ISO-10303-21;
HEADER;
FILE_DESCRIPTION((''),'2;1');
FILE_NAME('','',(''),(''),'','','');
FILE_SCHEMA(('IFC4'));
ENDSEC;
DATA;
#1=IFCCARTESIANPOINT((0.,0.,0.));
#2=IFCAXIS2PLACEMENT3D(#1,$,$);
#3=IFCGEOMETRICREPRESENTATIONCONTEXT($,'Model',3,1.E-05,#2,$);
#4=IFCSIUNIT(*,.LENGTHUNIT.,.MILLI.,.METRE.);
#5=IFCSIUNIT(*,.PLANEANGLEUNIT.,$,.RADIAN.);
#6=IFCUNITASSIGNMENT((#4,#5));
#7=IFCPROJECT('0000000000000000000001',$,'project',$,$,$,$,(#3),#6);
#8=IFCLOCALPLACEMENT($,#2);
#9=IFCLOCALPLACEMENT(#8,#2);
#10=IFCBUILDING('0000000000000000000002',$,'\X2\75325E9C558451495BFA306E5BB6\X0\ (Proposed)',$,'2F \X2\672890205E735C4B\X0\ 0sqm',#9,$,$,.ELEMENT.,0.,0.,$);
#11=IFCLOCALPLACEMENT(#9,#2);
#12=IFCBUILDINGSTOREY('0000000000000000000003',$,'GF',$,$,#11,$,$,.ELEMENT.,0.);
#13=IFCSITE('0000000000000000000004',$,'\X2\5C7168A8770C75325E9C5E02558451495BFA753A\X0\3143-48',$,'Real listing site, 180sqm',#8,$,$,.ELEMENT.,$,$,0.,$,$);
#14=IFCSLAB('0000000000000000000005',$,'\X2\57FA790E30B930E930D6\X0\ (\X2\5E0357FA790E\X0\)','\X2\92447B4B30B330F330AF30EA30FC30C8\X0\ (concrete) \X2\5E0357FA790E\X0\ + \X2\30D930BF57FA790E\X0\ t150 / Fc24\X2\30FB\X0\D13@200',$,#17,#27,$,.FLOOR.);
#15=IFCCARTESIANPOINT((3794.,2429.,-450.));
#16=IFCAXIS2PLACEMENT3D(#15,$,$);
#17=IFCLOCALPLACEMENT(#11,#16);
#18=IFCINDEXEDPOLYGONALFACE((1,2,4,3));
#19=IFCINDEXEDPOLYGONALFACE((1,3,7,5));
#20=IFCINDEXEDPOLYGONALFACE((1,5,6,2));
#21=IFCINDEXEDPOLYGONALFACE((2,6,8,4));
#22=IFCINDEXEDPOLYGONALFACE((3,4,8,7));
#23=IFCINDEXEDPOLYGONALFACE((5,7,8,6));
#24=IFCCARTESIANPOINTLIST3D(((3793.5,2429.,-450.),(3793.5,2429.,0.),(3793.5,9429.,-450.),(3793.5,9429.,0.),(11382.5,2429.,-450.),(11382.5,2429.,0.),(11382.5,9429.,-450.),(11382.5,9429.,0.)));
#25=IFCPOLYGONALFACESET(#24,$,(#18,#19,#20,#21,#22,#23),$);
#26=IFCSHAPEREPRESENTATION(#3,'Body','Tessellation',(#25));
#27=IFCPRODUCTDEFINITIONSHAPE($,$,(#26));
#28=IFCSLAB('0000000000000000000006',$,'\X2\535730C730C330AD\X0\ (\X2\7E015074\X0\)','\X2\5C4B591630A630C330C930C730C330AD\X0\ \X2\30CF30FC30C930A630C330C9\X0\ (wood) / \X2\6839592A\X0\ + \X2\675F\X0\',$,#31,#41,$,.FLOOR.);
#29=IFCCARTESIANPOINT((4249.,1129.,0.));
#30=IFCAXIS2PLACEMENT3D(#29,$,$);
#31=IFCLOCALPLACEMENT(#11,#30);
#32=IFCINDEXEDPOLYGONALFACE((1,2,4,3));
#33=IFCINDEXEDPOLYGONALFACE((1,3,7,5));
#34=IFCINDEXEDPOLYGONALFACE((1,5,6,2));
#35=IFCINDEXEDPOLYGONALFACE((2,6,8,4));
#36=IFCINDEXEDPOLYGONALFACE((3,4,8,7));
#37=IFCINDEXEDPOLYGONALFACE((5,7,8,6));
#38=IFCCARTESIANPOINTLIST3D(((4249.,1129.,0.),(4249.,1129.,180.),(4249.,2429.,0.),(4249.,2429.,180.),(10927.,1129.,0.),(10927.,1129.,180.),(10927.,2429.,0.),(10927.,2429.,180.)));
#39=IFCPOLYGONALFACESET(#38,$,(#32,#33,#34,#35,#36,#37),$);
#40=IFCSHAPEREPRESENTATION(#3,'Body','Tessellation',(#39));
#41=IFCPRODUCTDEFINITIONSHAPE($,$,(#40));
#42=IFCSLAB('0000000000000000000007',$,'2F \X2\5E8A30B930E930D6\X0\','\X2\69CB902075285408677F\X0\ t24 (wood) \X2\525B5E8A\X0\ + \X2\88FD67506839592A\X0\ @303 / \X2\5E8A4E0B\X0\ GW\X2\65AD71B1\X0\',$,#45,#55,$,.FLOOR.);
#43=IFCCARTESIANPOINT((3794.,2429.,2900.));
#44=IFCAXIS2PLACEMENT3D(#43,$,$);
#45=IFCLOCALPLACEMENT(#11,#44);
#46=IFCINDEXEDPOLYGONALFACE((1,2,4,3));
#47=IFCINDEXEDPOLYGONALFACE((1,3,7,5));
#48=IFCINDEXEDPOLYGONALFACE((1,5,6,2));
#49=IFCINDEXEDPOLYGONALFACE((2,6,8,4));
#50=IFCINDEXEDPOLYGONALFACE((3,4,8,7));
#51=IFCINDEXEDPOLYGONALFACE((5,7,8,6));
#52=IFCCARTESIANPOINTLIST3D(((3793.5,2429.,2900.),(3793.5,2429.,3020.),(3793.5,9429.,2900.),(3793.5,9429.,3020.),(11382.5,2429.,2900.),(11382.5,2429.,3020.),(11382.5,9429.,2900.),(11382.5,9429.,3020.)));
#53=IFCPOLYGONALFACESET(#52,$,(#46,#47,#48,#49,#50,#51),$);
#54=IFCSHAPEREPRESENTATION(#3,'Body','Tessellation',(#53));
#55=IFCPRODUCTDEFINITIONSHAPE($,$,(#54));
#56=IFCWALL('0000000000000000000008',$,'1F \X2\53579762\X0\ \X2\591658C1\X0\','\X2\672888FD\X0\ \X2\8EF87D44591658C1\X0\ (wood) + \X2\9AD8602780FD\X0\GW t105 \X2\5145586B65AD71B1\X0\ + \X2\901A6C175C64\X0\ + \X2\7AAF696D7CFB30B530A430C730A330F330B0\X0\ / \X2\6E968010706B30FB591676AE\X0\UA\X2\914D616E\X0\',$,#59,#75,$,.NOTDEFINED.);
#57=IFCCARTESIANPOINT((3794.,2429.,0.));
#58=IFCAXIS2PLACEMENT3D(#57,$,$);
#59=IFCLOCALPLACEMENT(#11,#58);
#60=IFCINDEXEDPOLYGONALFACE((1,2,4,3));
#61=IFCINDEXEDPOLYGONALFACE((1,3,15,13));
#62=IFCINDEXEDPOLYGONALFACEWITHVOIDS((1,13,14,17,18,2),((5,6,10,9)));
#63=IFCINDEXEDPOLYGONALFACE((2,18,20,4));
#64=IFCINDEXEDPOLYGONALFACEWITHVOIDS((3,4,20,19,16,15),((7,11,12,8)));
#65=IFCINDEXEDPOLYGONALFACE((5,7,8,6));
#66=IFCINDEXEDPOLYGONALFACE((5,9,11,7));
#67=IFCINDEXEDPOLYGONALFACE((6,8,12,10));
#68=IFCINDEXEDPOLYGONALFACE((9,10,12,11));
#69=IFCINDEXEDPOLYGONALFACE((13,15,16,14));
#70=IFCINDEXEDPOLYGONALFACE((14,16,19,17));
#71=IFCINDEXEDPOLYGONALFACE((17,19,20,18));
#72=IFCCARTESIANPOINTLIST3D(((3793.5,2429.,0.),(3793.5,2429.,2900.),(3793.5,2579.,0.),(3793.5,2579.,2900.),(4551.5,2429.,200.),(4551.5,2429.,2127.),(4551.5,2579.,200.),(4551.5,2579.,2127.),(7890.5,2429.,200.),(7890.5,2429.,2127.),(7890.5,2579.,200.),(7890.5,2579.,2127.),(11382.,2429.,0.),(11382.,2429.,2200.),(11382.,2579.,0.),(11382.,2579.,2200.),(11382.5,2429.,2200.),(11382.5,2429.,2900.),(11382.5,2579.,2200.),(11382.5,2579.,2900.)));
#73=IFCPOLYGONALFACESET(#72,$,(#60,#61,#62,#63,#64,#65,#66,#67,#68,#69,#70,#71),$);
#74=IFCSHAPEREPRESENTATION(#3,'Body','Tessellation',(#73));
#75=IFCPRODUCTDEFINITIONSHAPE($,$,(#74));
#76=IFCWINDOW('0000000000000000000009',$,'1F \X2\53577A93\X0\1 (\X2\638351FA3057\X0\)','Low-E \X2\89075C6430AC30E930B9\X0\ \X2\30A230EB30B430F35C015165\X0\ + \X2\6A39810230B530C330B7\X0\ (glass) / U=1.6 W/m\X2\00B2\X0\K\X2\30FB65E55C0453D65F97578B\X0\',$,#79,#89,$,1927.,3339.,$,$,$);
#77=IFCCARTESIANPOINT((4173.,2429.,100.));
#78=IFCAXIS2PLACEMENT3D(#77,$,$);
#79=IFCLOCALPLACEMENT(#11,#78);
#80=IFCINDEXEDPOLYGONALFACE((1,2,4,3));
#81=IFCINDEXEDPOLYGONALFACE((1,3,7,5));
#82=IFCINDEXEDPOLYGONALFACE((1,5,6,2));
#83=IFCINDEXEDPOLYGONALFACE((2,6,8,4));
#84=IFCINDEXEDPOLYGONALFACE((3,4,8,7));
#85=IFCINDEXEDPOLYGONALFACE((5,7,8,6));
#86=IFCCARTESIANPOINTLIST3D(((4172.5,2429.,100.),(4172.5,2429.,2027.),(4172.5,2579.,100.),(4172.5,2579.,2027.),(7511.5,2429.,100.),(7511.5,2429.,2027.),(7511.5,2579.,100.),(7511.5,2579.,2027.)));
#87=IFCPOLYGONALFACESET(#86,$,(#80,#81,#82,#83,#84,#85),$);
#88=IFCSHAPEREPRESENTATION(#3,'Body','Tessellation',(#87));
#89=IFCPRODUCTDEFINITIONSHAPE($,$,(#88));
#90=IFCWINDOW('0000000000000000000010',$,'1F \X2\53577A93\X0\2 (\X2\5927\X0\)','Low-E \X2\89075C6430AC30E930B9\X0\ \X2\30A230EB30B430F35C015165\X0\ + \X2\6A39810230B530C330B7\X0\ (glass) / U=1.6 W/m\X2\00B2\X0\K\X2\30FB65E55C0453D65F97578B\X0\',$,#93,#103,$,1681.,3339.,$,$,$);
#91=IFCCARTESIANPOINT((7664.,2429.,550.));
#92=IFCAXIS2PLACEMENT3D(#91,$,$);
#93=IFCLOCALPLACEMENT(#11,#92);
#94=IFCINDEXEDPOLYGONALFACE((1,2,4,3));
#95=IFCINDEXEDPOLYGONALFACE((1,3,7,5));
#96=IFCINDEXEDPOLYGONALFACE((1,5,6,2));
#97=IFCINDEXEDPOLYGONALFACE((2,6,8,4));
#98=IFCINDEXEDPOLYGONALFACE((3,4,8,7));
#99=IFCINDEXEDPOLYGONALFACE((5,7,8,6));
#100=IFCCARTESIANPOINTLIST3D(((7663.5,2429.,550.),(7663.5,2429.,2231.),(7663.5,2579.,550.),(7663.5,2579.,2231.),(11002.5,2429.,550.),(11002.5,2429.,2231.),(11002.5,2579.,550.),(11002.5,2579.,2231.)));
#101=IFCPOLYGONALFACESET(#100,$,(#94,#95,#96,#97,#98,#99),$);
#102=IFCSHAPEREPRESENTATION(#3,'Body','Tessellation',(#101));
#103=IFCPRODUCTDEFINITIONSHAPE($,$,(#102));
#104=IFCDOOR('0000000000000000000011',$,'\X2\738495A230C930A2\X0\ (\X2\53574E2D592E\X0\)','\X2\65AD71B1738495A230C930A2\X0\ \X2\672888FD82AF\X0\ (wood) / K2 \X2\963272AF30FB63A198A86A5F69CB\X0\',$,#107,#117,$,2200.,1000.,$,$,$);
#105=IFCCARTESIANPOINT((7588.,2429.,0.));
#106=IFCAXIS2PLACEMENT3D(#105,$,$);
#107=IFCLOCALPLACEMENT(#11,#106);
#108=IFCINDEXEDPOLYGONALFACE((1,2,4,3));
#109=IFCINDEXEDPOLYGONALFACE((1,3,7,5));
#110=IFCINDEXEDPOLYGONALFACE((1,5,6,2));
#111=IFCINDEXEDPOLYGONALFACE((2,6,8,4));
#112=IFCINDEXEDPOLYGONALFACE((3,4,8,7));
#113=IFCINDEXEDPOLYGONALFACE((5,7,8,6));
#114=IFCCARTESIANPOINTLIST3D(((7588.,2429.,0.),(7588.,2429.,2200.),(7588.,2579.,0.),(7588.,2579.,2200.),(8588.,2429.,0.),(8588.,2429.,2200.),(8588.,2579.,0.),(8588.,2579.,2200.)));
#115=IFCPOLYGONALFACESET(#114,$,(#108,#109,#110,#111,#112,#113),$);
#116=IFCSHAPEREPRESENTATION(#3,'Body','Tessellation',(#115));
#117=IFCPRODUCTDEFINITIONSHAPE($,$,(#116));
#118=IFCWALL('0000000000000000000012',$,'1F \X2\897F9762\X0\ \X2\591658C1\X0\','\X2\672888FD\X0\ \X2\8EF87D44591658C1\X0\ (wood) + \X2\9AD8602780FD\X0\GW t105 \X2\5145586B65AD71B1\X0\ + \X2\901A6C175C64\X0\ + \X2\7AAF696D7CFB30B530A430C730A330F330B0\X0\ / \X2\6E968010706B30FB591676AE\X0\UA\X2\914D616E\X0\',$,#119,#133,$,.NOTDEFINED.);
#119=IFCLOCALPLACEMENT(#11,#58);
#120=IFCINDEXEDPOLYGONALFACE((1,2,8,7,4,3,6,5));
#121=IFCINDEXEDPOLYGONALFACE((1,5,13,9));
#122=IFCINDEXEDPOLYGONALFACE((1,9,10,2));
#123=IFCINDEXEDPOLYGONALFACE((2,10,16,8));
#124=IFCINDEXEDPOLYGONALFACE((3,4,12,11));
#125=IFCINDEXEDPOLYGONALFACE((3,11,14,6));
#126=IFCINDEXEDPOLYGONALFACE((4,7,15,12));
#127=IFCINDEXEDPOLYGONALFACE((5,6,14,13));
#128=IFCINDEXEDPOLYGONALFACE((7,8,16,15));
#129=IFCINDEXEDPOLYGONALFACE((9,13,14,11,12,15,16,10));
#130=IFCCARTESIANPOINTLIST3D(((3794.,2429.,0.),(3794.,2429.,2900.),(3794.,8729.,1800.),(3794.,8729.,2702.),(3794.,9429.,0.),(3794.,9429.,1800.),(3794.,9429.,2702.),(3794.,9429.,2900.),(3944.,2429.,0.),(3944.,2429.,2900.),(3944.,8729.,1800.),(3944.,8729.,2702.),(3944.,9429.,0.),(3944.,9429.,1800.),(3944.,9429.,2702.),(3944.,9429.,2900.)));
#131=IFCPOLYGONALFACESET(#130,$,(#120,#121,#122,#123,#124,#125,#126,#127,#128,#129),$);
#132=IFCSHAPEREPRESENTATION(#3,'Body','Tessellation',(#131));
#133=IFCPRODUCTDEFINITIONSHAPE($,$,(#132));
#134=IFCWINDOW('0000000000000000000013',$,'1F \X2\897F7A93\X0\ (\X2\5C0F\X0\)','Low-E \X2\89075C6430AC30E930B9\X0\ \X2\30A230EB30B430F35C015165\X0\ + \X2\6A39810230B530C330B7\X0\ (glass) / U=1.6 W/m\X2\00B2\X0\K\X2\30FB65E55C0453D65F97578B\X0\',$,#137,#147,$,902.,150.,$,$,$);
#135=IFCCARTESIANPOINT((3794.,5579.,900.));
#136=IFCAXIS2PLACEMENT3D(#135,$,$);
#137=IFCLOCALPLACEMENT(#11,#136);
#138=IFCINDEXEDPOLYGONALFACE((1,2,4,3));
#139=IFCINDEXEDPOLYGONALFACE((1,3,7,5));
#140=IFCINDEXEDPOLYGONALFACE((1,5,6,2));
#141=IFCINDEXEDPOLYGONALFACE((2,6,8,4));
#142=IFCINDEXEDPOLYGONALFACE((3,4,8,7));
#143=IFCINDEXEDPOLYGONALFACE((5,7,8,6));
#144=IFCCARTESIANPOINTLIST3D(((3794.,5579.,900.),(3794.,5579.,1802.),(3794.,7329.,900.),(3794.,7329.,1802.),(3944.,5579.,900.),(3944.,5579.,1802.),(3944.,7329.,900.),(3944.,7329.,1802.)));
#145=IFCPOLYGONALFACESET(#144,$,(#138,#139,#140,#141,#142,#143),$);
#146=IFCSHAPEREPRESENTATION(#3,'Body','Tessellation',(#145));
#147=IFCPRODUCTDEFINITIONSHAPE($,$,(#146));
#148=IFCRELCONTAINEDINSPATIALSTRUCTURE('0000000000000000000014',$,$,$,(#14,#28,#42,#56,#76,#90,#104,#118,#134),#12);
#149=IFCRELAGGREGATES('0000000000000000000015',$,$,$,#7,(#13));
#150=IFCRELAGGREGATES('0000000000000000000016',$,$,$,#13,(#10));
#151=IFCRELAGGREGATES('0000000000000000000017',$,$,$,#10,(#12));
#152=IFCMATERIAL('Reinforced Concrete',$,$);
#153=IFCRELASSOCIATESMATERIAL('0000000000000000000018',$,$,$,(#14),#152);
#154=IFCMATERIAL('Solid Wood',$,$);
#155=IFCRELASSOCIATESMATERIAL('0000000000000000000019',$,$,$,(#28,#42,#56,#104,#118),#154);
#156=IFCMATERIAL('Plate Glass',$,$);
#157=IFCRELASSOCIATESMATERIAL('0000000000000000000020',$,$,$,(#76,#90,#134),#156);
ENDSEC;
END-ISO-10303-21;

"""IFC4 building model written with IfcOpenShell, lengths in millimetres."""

from ifc_helpers import new_model, si_unit, frame, frame_2d, origin, place, context, project, spatial, rectangle, extrude, material, element, fill, save


model = new_model("IFC4")

# Units and contexts
model_context = context("Model", 3, precision=1e-05, world=origin())
ifc_project = project(units=[si_unit("LENGTHUNIT", "METRE", prefix="MILLI"), si_unit("PLANEANGLEUNIT", "RADIAN")], contexts=[model_context])

# Site, building, storey
site_placement = place(None, origin())
site = spatial("IfcSite", under=ifc_project, at=site_placement, Name="山梨県甲府市善光寺町3143-48", ObjectType="Real listing site, 180sqm", CompositionType="ELEMENT", RefElevation=0.0)
building_placement = place(site_placement, origin())
building = spatial("IfcBuilding", under=site, at=building_placement, Name="甲府善光寺の家 (Proposed)", ObjectType="2F 木造平屋 0sqm", CompositionType="ELEMENT", ElevationOfRefHeight=0.0, ElevationOfTerrain=0.0)
storey_placement = place(building_placement, origin())
storey = spatial("IfcBuildingStorey", under=building, at=storey_placement, Name="GF", CompositionType="ELEMENT", Elevation=0.0)

# Slabs
ifc_material_1 = material(Name="Reinforced Concrete")
slab_1_placement = place(storey_placement, frame((3794.0, 2429.0, -450.0)))
element("IfcSlab", 1, at=slab_1_placement, inside=storey, material=ifc_material_1, Name="基礎スラブ (布基礎)", Description="鉄筋コンクリート (concrete) 布基礎 + ベタ基礎 t150 / Fc24・D13@200", PredefinedType="FLOOR", context=model_context, shape_type="SweptSolid", body=[
    extrude(rectangle(XDim=7589.0, YDim=7000.0, at=frame_2d((3794.0, 3500.0))), frame((3794.0, 2429.0, -450.0)), (0.0, 0.0, 1.0), 450.0),
])
ifc_material_2 = material(Name="Solid Wood")
slab_2_placement = place(storey_placement, frame((4249.0, 1129.0, 0.0)))
element("IfcSlab", 2, at=slab_2_placement, inside=storey, material=ifc_material_2, Name="南デッキ (縁側)", Description="屋外ウッドデッキ ハードウッド (wood) / 根太 + 束", PredefinedType="FLOOR", context=model_context, shape_type="SweptSolid", body=[
    extrude(rectangle(XDim=6678.0, YDim=1300.0, at=frame_2d((3339.0, 650.0))), frame((4249.0, 1129.0, 0.0)), (0.0, 0.0, 1.0), 180.0),
])
slab_3_placement = place(storey_placement, frame((3794.0, 2429.0, 2900.0)))
element("IfcSlab", 3, at=slab_3_placement, inside=storey, material=ifc_material_2, Name="2F 床スラブ", Description="構造用合板 t24 (wood) 剛床 + 製材根太 @303 / 床下 GW断熱", PredefinedType="FLOOR", context=model_context, shape_type="SweptSolid", body=[
    extrude(rectangle(XDim=7589.0, YDim=7000.0, at=frame_2d((3794.0, 3500.0))), frame((3794.0, 2429.0, 2900.0)), (0.0, 0.0, 1.0), 120.0),
])

# Wall, openings, windows, door
wall_1_placement = place(storey_placement, frame((3794.0, 2429.0, 0.0)))
wall_1 = element("IfcWall", 4, at=wall_1_placement, inside=storey, material=ifc_material_2, Name="1F 南面 外壁", Description="木製 軸組外壁 (wood) + 高性能GW t105 充填断熱 + 通気層 + 窯業系サイディング / 準耐火・外皮UA配慮", PredefinedType="NOTDEFINED", context=model_context, shape_type="SweptSolid", body=[
    extrude(rectangle(XDim=7589.0, YDim=150.0, at=frame_2d((3794.0, 75.0))), frame((3794.0, 2429.0, 0.0)), (0.0, 0.0, 1.0), 2900.0),
])
opening_1_placement = place(storey_placement, frame((4173.0, 2429.0, 100.0)))
opening_1 = element("IfcOpeningElement", 5, at=opening_1_placement, cuts=wall_1, PredefinedType="NOTDEFINED", context=model_context, shape_type="SweptSolid", body=[
    extrude(rectangle(XDim=3339.0, YDim=150.0, at=frame_2d((1669.0, 75.0))), frame((4173.0, 2429.0, 100.0)), (0.0, 0.0, 1.0), 1927.0),
])
opening_2_placement = place(storey_placement, frame((7664.0, 2429.0, 550.0)))
opening_2 = element("IfcOpeningElement", 6, at=opening_2_placement, cuts=wall_1, PredefinedType="NOTDEFINED", context=model_context, shape_type="SweptSolid", body=[
    extrude(rectangle(XDim=3339.0, YDim=150.0, at=frame_2d((1669.0, 75.0))), frame((7664.0, 2429.0, 550.0)), (0.0, 0.0, 1.0), 1681.0),
])
opening_3_placement = place(storey_placement, frame((7588.0, 2429.0, 0.0)))
opening_3 = element("IfcOpeningElement", 7, at=opening_3_placement, cuts=wall_1, PredefinedType="NOTDEFINED", context=model_context, shape_type="SweptSolid", body=[
    extrude(rectangle(XDim=1000.0, YDim=150.0, at=frame_2d((500.0, 75.0))), frame((7588.0, 2429.0, 0.0)), (0.0, 0.0, 1.0), 2200.0),
])
ifc_material_3 = material(Name="Plate Glass")
window_1_placement = place(storey_placement, frame((4173.0, 2429.0, 100.0)))
window_1 = element("IfcWindow", 8, at=window_1_placement, inside=storey, material=ifc_material_3, Name="1F 南窓1 (掃出し)", Description="Low-E 複層ガラス アルゴン封入 + 樹脂サッシ (glass) / U=1.6 W/m²K・日射取得型", OverallHeight=1927.0, OverallWidth=3339.0, context=model_context, shape_type="SweptSolid", body=[
    extrude(rectangle(XDim=3339.0, YDim=150.0, at=frame_2d((1669.0, 75.0))), frame((4173.0, 2429.0, 100.0)), (0.0, 0.0, 1.0), 1927.0),
])
fill(opening_1, window_1)
window_2_placement = place(storey_placement, frame((7664.0, 2429.0, 550.0)))
window_2 = element("IfcWindow", 9, at=window_2_placement, inside=storey, material=ifc_material_3, Name="1F 南窓2 (大)", Description="Low-E 複層ガラス アルゴン封入 + 樹脂サッシ (glass) / U=1.6 W/m²K・日射取得型", OverallHeight=1681.0, OverallWidth=3339.0, context=model_context, shape_type="SweptSolid", body=[
    extrude(rectangle(XDim=3339.0, YDim=150.0, at=frame_2d((1669.0, 75.0))), frame((7664.0, 2429.0, 550.0)), (0.0, 0.0, 1.0), 1681.0),
])
fill(opening_2, window_2)
door_placement = place(storey_placement, frame((7588.0, 2429.0, 0.0)))
door = element("IfcDoor", 10, at=door_placement, inside=storey, material=ifc_material_2, Name="玄関ドア (南中央)", Description="断熱玄関ドア 木製芯 (wood) / K2 防犯・採風機構", OverallHeight=2200.0, OverallWidth=1000.0, context=model_context, shape_type="SweptSolid", body=[
    extrude(rectangle(XDim=1000.0, YDim=150.0, at=frame_2d((500.0, 75.0))), frame((7588.0, 2429.0, 0.0)), (0.0, 0.0, 1.0), 2200.0),
])
fill(opening_3, door)

# Wall, opening, window
wall_2_placement = place(storey_placement, frame((3794.0, 2429.0, 0.0)))
wall_2 = element("IfcWall", 11, at=wall_2_placement, inside=storey, material=ifc_material_2, Name="1F 西面 外壁", Description="木製 軸組外壁 (wood) + 高性能GW t105 充填断熱 + 通気層 + 窯業系サイディング / 準耐火・外皮UA配慮", PredefinedType="NOTDEFINED", context=model_context, shape_type="SweptSolid", body=[
    extrude(rectangle(XDim=150.0, YDim=7000.0, at=frame_2d((75.0, 3500.0))), frame((3794.0, 2429.0, 0.0)), (0.0, 0.0, 1.0), 2900.0),
])
opening_4_placement = place(storey_placement, frame((3794.0, 5579.0, 900.0)))
opening_4 = element("IfcOpeningElement", 12, at=opening_4_placement, cuts=wall_2, PredefinedType="NOTDEFINED", context=model_context, shape_type="SweptSolid", body=[
    extrude(rectangle(XDim=150.0, YDim=1750.0, at=frame_2d((75.0, 875.0))), frame((3794.0, 5579.0, 900.0)), (0.0, 0.0, 1.0), 902.0),
])
window_3_placement = place(storey_placement, frame((3794.0, 5579.0, 900.0)))
window_3 = element("IfcWindow", 13, at=window_3_placement, inside=storey, material=ifc_material_3, Name="1F 西窓 (小)", Description="Low-E 複層ガラス アルゴン封入 + 樹脂サッシ (glass) / U=1.6 W/m²K・日射取得型", OverallHeight=902.0, OverallWidth=150.0, context=model_context, shape_type="SweptSolid", body=[
    extrude(rectangle(XDim=150.0, YDim=1750.0, at=frame_2d((75.0, 875.0))), frame((3794.0, 5579.0, 900.0)), (0.0, 0.0, 1.0), 902.0),
])
fill(opening_4, window_3)

save(model, "model.ifc")
